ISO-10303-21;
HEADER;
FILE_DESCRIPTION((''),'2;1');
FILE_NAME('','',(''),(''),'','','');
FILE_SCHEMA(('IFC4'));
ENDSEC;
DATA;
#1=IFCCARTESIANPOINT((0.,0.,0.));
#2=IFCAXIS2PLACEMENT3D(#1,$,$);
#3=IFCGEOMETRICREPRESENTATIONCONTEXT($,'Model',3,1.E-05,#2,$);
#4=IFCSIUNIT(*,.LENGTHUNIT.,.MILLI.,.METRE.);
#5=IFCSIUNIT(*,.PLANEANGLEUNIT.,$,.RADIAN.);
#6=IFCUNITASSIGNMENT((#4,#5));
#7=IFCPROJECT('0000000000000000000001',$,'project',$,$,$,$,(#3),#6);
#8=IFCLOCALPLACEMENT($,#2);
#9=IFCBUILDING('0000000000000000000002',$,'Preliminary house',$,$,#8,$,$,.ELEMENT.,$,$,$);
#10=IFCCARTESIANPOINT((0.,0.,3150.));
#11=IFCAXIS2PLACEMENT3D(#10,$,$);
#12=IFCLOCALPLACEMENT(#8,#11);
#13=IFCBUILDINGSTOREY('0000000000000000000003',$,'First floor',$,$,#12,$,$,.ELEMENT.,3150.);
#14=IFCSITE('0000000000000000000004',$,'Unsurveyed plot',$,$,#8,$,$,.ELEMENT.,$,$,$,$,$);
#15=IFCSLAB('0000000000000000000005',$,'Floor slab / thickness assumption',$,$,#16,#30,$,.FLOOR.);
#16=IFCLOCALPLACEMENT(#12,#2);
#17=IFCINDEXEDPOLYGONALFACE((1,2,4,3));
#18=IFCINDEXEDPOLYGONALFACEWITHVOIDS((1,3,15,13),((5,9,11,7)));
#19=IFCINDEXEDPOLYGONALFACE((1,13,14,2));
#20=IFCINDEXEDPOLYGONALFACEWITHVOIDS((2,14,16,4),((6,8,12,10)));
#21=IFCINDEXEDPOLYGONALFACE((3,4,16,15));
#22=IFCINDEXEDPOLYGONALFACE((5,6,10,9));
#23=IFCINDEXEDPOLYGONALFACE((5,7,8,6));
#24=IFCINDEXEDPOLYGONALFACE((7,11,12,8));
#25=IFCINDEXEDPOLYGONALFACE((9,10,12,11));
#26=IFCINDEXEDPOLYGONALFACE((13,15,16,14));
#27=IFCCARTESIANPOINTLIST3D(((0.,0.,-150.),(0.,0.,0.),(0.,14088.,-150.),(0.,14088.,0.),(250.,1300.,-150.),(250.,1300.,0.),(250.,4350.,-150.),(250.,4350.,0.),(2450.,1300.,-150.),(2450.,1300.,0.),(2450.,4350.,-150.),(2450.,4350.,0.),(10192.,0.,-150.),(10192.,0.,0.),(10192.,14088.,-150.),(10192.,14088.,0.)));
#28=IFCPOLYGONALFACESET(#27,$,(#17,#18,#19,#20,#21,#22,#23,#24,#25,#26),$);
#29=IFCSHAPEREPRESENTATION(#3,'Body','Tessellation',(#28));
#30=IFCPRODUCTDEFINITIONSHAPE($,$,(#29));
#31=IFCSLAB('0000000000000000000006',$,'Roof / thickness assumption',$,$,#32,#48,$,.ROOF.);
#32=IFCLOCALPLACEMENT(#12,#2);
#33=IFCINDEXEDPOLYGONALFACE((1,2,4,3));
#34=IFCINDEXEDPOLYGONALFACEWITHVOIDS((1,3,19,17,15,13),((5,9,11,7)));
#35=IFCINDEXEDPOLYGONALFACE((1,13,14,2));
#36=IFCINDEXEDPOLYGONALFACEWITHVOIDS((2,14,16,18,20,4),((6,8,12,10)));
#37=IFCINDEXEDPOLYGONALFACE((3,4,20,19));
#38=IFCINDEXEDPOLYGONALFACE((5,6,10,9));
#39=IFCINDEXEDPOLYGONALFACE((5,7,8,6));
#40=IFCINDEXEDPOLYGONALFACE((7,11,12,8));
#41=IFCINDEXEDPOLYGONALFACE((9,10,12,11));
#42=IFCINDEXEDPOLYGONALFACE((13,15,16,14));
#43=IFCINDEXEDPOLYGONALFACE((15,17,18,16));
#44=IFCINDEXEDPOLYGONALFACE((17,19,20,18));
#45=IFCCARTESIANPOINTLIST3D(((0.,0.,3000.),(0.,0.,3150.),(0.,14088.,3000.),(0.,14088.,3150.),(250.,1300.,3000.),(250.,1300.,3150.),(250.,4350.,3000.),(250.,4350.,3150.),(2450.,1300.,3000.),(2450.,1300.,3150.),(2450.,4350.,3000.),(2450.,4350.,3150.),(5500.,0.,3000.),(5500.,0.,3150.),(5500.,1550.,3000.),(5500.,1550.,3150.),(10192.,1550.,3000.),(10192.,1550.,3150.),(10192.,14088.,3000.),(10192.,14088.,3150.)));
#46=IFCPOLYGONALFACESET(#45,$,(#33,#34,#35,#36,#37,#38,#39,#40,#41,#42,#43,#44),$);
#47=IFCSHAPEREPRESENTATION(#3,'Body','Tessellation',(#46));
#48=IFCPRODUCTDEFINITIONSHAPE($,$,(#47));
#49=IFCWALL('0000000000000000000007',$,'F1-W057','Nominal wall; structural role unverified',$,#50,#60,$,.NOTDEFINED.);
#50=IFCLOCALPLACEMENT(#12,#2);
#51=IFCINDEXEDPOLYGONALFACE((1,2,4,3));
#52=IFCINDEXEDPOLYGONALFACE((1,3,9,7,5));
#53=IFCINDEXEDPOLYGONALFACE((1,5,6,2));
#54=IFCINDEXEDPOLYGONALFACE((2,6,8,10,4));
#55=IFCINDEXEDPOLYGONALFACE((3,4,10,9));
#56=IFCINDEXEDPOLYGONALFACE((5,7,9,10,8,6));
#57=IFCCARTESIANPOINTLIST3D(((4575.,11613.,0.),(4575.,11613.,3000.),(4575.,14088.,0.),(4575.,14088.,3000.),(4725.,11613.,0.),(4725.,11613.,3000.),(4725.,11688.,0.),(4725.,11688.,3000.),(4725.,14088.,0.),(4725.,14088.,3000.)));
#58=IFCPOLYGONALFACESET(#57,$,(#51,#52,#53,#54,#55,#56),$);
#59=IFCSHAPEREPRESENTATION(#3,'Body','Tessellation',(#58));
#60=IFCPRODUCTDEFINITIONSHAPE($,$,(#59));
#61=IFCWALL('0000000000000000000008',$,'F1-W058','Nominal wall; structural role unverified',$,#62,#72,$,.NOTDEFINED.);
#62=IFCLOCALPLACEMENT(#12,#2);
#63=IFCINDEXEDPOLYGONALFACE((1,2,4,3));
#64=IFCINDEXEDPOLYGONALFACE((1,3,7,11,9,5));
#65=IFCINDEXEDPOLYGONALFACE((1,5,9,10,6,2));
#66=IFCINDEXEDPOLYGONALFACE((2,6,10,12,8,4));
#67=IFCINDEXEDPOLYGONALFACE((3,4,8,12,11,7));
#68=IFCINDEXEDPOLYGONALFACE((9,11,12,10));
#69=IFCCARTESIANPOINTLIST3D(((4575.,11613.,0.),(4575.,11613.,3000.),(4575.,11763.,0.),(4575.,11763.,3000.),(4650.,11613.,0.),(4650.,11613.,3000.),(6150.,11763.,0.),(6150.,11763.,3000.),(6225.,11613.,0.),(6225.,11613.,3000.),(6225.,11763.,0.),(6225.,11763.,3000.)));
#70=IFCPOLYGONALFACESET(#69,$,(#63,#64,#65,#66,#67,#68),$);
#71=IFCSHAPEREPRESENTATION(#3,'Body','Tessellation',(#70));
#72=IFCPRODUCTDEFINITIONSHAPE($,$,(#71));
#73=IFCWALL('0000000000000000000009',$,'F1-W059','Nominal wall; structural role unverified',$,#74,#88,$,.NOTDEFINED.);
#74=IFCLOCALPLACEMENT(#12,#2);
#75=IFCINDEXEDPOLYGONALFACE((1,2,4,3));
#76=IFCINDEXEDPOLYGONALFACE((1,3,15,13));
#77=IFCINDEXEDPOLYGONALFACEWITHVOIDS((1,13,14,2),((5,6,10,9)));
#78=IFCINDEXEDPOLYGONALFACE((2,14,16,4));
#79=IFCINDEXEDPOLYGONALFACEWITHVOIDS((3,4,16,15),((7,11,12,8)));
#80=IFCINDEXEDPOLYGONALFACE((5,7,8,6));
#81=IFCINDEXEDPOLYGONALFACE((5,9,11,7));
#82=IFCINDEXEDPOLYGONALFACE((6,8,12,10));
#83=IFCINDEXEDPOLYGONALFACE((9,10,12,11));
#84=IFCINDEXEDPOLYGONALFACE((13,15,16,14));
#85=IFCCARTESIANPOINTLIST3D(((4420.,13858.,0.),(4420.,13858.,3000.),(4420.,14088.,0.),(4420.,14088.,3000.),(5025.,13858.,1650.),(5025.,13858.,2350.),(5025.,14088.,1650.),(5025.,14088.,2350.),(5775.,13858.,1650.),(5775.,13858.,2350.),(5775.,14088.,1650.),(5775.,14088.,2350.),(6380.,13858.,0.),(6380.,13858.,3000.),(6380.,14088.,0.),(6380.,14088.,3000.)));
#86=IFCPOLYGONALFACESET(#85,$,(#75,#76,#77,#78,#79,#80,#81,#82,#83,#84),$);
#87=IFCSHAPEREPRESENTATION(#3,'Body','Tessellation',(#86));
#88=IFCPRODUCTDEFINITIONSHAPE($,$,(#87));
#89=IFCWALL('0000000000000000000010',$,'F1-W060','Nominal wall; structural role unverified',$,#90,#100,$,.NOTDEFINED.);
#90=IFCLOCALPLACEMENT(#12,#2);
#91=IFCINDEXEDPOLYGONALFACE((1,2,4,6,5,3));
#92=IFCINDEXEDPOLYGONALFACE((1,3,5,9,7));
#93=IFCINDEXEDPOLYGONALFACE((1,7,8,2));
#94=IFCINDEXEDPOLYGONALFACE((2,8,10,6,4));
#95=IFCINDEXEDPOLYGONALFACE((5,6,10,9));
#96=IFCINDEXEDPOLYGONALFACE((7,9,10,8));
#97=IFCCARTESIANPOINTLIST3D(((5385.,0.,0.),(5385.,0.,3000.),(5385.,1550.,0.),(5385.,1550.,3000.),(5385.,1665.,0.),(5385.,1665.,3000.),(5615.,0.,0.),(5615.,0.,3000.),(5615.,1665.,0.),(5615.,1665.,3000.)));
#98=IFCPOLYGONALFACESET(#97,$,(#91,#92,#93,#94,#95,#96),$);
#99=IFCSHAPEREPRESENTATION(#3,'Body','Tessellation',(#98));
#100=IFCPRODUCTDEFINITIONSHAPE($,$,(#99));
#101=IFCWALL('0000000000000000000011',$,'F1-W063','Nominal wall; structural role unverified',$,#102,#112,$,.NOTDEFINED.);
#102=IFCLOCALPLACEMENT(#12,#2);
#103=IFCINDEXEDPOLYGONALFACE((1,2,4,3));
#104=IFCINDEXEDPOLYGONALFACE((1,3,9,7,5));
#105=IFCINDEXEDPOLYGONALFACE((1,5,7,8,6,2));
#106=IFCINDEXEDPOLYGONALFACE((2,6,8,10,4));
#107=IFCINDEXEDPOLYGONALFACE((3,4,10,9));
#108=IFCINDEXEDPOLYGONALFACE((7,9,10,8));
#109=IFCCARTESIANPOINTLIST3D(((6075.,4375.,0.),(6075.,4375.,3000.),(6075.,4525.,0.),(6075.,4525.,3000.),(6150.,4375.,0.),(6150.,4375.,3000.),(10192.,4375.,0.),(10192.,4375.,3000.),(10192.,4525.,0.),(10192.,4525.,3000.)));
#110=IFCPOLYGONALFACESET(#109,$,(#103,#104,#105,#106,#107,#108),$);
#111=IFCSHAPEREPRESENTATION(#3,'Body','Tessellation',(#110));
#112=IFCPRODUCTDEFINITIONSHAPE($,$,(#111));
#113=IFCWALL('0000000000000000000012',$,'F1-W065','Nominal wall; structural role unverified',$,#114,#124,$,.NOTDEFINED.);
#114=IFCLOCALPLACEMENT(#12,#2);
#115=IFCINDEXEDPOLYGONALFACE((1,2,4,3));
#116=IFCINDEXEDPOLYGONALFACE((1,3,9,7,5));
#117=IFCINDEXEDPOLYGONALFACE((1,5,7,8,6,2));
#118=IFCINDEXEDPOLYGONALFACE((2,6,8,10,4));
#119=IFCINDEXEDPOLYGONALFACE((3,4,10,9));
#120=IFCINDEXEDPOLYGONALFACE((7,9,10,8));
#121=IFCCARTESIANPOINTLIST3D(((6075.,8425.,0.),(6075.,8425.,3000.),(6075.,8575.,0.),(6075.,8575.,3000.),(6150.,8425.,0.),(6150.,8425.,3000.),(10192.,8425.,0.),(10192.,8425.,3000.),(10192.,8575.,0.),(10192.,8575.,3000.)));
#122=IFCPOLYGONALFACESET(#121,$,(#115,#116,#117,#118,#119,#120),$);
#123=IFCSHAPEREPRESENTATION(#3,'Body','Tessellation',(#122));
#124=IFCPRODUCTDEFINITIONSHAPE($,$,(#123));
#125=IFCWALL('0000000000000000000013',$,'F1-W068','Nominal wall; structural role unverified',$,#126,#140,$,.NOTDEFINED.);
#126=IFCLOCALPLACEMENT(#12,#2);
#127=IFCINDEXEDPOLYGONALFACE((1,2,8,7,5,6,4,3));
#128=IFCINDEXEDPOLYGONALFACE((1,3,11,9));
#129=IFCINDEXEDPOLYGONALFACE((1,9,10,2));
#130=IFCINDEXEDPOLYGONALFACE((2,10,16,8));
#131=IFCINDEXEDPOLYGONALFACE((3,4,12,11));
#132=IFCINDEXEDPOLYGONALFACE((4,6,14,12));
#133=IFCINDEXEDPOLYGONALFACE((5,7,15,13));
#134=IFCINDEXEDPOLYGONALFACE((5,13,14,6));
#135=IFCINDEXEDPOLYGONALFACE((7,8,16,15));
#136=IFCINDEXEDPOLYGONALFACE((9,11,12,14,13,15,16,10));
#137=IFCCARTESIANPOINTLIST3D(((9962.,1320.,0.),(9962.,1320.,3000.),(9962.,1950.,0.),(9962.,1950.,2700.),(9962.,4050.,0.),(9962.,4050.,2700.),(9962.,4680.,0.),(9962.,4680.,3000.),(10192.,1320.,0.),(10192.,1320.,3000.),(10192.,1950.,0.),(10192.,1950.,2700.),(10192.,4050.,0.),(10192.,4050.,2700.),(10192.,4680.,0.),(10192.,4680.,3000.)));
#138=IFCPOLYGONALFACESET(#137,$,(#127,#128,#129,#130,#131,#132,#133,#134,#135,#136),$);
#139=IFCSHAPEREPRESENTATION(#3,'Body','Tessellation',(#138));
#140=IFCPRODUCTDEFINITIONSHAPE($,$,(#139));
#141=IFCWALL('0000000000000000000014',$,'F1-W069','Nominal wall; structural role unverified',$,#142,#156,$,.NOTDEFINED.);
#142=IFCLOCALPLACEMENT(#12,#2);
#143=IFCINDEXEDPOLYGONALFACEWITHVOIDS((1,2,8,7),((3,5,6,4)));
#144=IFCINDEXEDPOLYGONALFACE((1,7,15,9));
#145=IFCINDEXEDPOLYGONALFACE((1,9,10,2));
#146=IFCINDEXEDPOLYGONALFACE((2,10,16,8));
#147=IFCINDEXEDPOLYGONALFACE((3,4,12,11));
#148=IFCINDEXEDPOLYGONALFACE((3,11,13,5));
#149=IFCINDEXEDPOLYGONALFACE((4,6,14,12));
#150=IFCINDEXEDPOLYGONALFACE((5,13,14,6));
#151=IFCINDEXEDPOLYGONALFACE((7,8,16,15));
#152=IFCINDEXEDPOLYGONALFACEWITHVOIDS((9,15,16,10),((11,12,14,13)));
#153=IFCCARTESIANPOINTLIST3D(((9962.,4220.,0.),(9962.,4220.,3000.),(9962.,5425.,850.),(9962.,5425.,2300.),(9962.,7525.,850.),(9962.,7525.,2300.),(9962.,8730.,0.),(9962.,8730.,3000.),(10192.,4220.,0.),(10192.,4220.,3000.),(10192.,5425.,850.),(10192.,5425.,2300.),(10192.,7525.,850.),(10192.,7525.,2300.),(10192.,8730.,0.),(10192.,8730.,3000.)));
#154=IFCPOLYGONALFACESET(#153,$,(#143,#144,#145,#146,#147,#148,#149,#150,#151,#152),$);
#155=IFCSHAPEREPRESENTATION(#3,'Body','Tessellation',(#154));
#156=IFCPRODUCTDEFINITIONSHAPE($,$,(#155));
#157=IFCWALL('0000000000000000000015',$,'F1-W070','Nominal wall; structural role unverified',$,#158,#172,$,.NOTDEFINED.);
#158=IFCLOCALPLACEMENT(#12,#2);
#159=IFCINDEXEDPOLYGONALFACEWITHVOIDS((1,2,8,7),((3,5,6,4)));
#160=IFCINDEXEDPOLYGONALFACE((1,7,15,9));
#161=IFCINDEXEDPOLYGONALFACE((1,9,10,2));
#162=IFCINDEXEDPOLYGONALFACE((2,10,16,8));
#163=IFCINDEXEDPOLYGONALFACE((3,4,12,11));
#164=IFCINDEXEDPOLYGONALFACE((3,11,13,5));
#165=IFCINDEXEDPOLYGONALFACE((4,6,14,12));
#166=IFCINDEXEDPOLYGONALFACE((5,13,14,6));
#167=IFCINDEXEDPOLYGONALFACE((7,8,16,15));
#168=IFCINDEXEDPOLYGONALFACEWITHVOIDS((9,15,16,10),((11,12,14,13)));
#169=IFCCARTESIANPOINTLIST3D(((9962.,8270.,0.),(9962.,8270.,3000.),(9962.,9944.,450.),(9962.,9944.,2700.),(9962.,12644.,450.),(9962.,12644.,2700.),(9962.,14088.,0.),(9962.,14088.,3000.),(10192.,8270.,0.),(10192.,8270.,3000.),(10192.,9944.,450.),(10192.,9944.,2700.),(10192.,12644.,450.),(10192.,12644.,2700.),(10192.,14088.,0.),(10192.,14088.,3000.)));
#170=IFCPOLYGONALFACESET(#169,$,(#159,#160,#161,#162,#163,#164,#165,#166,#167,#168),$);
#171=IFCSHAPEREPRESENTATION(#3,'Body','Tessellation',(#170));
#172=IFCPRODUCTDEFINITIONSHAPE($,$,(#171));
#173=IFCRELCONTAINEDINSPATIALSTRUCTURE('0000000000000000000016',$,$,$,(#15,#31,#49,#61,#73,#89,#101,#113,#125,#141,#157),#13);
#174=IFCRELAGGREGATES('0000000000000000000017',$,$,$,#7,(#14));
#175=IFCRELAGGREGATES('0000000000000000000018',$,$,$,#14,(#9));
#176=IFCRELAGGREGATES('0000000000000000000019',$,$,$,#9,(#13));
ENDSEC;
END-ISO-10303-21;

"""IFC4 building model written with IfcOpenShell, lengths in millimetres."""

from ifc_helpers import new_model, si_unit, frame, origin, place, context, project, spatial, polyline, outline, extrude, element, save


model = new_model("IFC4")

# Units and contexts
model_context = context("Model", 3, precision=1e-05, world=origin())
ifc_project = project(units=[si_unit("LENGTHUNIT", "METRE", prefix="MILLI"), si_unit("PLANEANGLEUNIT", "RADIAN")], contexts=[model_context])

# Site, building, storey
placement_1 = place(None, origin())
site = spatial("IfcSite", under=ifc_project, at=placement_1, Name="Unsurveyed plot", CompositionType="ELEMENT")
building = spatial("IfcBuilding", under=site, at=placement_1, Name="Preliminary house", CompositionType="ELEMENT")
placement_2 = place(placement_1, frame((0.0, 0.0, 3150.0)))
storey = spatial("IfcBuildingStorey", under=building, at=placement_2, Name="First floor", CompositionType="ELEMENT", Elevation=3150.0)

# Slabs
element("IfcSlab", 1, at=placement_2, inside=storey, Name="Floor slab / thickness assumption", PredefinedType="FLOOR", context=model_context, shape_type="SweptSolid", body=[
    extrude(outline(polyline([(0.0, 0.0), (0.0, 14088.0), (10192.0, 14088.0), (10192.0, 0.0), (0.0, 0.0)]), holes=[polyline([(2450.0, 4350.0), (250.0, 4350.0), (250.0, 1300.0), (2450.0, 1300.0), (2450.0, 4350.0)])]), frame((0.0, 0.0, -150.0)), (0.0, 0.0, 1.0), 150.0),
])
element("IfcSlab", 2, at=placement_2, inside=storey, Name="Roof / thickness assumption", PredefinedType="ROOF", context=model_context, shape_type="SweptSolid", body=[
    extrude(outline(polyline([(0.0, 14088.0), (10192.0, 14088.0), (10192.0, 1550.0), (5500.0, 1550.0), (5500.0, 0.0), (0.0, 0.0), (0.0, 14088.0)]), holes=[polyline([(2450.0, 4350.0), (250.0, 4350.0), (250.0, 1300.0), (2450.0, 1300.0), (2450.0, 4350.0)])]), frame((0.0, 0.0, 3000.0)), (0.0, 0.0, 1.0), 150.0),
])

# Walls
element("IfcWall", 3, at=placement_2, inside=storey, Name="F1-W057", Description="Nominal wall; structural role unverified", PredefinedType="NOTDEFINED", context=model_context, shape_type="SweptSolid", body=[
    extrude(outline(polyline([(4725.0, 11688.0), (4725.0, 11613.0), (4575.0, 11613.0), (4575.0, 14088.0), (4725.0, 14088.0), (4725.0, 11688.0)])), origin(), (0.0, 0.0, 1.0), 3000.0),
])
element("IfcWall", 4, at=placement_2, inside=storey, Name="F1-W058", Description="Nominal wall; structural role unverified", PredefinedType="NOTDEFINED", context=model_context, shape_type="SweptSolid", body=[
    extrude(outline(polyline([(6225.0, 11763.0), (6225.0, 11613.0), (4650.0, 11613.0), (4575.0, 11613.0), (4575.0, 11763.0), (6150.0, 11763.0), (6225.0, 11763.0)])), origin(), (0.0, 0.0, 1.0), 3000.0),
])

# Wall, opening
wall_1 = element("IfcWall", 5, at=placement_2, inside=storey, Name="F1-W059", Description="Nominal wall; structural role unverified", PredefinedType="NOTDEFINED", context=model_context, shape_type="SweptSolid", body=[
    extrude(outline(polyline([(6380.0, 13858.0), (4650.0, 13858.0), (4420.0, 13858.0), (4420.0, 14088.0), (6380.0, 14088.0), (6380.0, 13858.0)])), origin(), (0.0, 0.0, 1.0), 3000.0),
])
element("IfcOpeningElement", 6, at=placement_2, cuts=wall_1, PredefinedType="OPENING", context=model_context, shape_type="SweptSolid", body=[
    extrude(outline(polyline([(5025.0, 13443.0), (5775.0, 13443.0), (5775.0, 14503.0), (5025.0, 14503.0), (5025.0, 13443.0)])), frame((0.0, 0.0, 1650.0)), (0.0, 0.0, 1.0), 700.0),
])

# Wall
element("IfcWall", 7, at=placement_2, inside=storey, Name="F1-W060", Description="Nominal wall; structural role unverified", PredefinedType="NOTDEFINED", context=model_context, shape_type="SweptSolid", body=[
    extrude(outline(polyline([(5385.0, 1665.0), (5615.0, 1665.0), (5615.0, 0.0), (5385.0, 0.0), (5385.0, 1550.0), (5385.0, 1665.0)])), origin(), (0.0, 0.0, 1.0), 3000.0),
])

# Wall
element("IfcWall", 8, at=placement_2, inside=storey, Name="F1-W063", Description="Nominal wall; structural role unverified", PredefinedType="NOTDEFINED", context=model_context, shape_type="SweptSolid", body=[
    extrude(outline(polyline([(6150.0, 4375.0), (6075.0, 4375.0), (6075.0, 4525.0), (10192.0, 4525.0), (10192.0, 4375.0), (6150.0, 4375.0)])), origin(), (0.0, 0.0, 1.0), 3000.0),
])

# Wall
element("IfcWall", 9, at=placement_2, inside=storey, Name="F1-W065", Description="Nominal wall; structural role unverified", PredefinedType="NOTDEFINED", context=model_context, shape_type="SweptSolid", body=[
    extrude(outline(polyline([(6150.0, 8425.0), (6075.0, 8425.0), (6075.0, 8575.0), (10192.0, 8575.0), (10192.0, 8425.0), (6150.0, 8425.0)])), origin(), (0.0, 0.0, 1.0), 3000.0),
])

# Walls, openings
wall_2 = element("IfcWall", 10, at=placement_2, inside=storey, Name="F1-W068", Description="Nominal wall; structural role unverified", PredefinedType="NOTDEFINED", context=model_context, shape_type="SweptSolid", body=[
    extrude(outline(polyline([(9962.0, 4680.0), (10192.0, 4680.0), (10192.0, 1320.0), (9962.0, 1320.0), (9962.0, 4450.0), (9962.0, 4680.0)])), origin(), (0.0, 0.0, 1.0), 3000.0),
])
element("IfcOpeningElement", 11, at=placement_2, cuts=wall_2, PredefinedType="OPENING", context=model_context, shape_type="SweptSolid", body=[
    extrude(outline(polyline([(10607.0, 1950.0), (10607.0, 4050.0), (9547.0, 4050.0), (9547.0, 1950.0), (10607.0, 1950.0)])), origin(), (0.0, 0.0, 1.0), 2700.0),
])
wall_3 = element("IfcWall", 12, at=placement_2, inside=storey, Name="F1-W069", Description="Nominal wall; structural role unverified", PredefinedType="NOTDEFINED", context=model_context, shape_type="SweptSolid", body=[
    extrude(outline(polyline([(9962.0, 8730.0), (10192.0, 8730.0), (10192.0, 4220.0), (9962.0, 4220.0), (9962.0, 8500.0), (9962.0, 8730.0)])), origin(), (0.0, 0.0, 1.0), 3000.0),
])
element("IfcOpeningElement", 13, at=placement_2, cuts=wall_3, PredefinedType="OPENING", context=model_context, shape_type="SweptSolid", body=[
    extrude(outline(polyline([(10607.0, 5425.0), (10607.0, 7525.0), (9547.0, 7525.0), (9547.0, 5425.0), (10607.0, 5425.0)])), frame((0.0, 0.0, 850.0)), (0.0, 0.0, 1.0), 1450.0),
])
wall_4 = element("IfcWall", 14, at=placement_2, inside=storey, Name="F1-W070", Description="Nominal wall; structural role unverified", PredefinedType="NOTDEFINED", context=model_context, shape_type="SweptSolid", body=[
    extrude(outline(polyline([(9962.0, 8270.0), (9962.0, 14088.0), (10192.0, 14088.0), (10192.0, 8270.0), (9962.0, 8270.0)])), origin(), (0.0, 0.0, 1.0), 3000.0),
])
element("IfcOpeningElement", 15, at=placement_2, cuts=wall_4, PredefinedType="OPENING", context=model_context, shape_type="SweptSolid", body=[
    extrude(outline(polyline([(10607.0, 9944.0), (10607.0, 12644.0), (9547.0, 12644.0), (9547.0, 9944.0), (10607.0, 9944.0)])), frame((0.0, 0.0, 450.0)), (0.0, 0.0, 1.0), 2250.0),
])

save(model, "model.ifc")
